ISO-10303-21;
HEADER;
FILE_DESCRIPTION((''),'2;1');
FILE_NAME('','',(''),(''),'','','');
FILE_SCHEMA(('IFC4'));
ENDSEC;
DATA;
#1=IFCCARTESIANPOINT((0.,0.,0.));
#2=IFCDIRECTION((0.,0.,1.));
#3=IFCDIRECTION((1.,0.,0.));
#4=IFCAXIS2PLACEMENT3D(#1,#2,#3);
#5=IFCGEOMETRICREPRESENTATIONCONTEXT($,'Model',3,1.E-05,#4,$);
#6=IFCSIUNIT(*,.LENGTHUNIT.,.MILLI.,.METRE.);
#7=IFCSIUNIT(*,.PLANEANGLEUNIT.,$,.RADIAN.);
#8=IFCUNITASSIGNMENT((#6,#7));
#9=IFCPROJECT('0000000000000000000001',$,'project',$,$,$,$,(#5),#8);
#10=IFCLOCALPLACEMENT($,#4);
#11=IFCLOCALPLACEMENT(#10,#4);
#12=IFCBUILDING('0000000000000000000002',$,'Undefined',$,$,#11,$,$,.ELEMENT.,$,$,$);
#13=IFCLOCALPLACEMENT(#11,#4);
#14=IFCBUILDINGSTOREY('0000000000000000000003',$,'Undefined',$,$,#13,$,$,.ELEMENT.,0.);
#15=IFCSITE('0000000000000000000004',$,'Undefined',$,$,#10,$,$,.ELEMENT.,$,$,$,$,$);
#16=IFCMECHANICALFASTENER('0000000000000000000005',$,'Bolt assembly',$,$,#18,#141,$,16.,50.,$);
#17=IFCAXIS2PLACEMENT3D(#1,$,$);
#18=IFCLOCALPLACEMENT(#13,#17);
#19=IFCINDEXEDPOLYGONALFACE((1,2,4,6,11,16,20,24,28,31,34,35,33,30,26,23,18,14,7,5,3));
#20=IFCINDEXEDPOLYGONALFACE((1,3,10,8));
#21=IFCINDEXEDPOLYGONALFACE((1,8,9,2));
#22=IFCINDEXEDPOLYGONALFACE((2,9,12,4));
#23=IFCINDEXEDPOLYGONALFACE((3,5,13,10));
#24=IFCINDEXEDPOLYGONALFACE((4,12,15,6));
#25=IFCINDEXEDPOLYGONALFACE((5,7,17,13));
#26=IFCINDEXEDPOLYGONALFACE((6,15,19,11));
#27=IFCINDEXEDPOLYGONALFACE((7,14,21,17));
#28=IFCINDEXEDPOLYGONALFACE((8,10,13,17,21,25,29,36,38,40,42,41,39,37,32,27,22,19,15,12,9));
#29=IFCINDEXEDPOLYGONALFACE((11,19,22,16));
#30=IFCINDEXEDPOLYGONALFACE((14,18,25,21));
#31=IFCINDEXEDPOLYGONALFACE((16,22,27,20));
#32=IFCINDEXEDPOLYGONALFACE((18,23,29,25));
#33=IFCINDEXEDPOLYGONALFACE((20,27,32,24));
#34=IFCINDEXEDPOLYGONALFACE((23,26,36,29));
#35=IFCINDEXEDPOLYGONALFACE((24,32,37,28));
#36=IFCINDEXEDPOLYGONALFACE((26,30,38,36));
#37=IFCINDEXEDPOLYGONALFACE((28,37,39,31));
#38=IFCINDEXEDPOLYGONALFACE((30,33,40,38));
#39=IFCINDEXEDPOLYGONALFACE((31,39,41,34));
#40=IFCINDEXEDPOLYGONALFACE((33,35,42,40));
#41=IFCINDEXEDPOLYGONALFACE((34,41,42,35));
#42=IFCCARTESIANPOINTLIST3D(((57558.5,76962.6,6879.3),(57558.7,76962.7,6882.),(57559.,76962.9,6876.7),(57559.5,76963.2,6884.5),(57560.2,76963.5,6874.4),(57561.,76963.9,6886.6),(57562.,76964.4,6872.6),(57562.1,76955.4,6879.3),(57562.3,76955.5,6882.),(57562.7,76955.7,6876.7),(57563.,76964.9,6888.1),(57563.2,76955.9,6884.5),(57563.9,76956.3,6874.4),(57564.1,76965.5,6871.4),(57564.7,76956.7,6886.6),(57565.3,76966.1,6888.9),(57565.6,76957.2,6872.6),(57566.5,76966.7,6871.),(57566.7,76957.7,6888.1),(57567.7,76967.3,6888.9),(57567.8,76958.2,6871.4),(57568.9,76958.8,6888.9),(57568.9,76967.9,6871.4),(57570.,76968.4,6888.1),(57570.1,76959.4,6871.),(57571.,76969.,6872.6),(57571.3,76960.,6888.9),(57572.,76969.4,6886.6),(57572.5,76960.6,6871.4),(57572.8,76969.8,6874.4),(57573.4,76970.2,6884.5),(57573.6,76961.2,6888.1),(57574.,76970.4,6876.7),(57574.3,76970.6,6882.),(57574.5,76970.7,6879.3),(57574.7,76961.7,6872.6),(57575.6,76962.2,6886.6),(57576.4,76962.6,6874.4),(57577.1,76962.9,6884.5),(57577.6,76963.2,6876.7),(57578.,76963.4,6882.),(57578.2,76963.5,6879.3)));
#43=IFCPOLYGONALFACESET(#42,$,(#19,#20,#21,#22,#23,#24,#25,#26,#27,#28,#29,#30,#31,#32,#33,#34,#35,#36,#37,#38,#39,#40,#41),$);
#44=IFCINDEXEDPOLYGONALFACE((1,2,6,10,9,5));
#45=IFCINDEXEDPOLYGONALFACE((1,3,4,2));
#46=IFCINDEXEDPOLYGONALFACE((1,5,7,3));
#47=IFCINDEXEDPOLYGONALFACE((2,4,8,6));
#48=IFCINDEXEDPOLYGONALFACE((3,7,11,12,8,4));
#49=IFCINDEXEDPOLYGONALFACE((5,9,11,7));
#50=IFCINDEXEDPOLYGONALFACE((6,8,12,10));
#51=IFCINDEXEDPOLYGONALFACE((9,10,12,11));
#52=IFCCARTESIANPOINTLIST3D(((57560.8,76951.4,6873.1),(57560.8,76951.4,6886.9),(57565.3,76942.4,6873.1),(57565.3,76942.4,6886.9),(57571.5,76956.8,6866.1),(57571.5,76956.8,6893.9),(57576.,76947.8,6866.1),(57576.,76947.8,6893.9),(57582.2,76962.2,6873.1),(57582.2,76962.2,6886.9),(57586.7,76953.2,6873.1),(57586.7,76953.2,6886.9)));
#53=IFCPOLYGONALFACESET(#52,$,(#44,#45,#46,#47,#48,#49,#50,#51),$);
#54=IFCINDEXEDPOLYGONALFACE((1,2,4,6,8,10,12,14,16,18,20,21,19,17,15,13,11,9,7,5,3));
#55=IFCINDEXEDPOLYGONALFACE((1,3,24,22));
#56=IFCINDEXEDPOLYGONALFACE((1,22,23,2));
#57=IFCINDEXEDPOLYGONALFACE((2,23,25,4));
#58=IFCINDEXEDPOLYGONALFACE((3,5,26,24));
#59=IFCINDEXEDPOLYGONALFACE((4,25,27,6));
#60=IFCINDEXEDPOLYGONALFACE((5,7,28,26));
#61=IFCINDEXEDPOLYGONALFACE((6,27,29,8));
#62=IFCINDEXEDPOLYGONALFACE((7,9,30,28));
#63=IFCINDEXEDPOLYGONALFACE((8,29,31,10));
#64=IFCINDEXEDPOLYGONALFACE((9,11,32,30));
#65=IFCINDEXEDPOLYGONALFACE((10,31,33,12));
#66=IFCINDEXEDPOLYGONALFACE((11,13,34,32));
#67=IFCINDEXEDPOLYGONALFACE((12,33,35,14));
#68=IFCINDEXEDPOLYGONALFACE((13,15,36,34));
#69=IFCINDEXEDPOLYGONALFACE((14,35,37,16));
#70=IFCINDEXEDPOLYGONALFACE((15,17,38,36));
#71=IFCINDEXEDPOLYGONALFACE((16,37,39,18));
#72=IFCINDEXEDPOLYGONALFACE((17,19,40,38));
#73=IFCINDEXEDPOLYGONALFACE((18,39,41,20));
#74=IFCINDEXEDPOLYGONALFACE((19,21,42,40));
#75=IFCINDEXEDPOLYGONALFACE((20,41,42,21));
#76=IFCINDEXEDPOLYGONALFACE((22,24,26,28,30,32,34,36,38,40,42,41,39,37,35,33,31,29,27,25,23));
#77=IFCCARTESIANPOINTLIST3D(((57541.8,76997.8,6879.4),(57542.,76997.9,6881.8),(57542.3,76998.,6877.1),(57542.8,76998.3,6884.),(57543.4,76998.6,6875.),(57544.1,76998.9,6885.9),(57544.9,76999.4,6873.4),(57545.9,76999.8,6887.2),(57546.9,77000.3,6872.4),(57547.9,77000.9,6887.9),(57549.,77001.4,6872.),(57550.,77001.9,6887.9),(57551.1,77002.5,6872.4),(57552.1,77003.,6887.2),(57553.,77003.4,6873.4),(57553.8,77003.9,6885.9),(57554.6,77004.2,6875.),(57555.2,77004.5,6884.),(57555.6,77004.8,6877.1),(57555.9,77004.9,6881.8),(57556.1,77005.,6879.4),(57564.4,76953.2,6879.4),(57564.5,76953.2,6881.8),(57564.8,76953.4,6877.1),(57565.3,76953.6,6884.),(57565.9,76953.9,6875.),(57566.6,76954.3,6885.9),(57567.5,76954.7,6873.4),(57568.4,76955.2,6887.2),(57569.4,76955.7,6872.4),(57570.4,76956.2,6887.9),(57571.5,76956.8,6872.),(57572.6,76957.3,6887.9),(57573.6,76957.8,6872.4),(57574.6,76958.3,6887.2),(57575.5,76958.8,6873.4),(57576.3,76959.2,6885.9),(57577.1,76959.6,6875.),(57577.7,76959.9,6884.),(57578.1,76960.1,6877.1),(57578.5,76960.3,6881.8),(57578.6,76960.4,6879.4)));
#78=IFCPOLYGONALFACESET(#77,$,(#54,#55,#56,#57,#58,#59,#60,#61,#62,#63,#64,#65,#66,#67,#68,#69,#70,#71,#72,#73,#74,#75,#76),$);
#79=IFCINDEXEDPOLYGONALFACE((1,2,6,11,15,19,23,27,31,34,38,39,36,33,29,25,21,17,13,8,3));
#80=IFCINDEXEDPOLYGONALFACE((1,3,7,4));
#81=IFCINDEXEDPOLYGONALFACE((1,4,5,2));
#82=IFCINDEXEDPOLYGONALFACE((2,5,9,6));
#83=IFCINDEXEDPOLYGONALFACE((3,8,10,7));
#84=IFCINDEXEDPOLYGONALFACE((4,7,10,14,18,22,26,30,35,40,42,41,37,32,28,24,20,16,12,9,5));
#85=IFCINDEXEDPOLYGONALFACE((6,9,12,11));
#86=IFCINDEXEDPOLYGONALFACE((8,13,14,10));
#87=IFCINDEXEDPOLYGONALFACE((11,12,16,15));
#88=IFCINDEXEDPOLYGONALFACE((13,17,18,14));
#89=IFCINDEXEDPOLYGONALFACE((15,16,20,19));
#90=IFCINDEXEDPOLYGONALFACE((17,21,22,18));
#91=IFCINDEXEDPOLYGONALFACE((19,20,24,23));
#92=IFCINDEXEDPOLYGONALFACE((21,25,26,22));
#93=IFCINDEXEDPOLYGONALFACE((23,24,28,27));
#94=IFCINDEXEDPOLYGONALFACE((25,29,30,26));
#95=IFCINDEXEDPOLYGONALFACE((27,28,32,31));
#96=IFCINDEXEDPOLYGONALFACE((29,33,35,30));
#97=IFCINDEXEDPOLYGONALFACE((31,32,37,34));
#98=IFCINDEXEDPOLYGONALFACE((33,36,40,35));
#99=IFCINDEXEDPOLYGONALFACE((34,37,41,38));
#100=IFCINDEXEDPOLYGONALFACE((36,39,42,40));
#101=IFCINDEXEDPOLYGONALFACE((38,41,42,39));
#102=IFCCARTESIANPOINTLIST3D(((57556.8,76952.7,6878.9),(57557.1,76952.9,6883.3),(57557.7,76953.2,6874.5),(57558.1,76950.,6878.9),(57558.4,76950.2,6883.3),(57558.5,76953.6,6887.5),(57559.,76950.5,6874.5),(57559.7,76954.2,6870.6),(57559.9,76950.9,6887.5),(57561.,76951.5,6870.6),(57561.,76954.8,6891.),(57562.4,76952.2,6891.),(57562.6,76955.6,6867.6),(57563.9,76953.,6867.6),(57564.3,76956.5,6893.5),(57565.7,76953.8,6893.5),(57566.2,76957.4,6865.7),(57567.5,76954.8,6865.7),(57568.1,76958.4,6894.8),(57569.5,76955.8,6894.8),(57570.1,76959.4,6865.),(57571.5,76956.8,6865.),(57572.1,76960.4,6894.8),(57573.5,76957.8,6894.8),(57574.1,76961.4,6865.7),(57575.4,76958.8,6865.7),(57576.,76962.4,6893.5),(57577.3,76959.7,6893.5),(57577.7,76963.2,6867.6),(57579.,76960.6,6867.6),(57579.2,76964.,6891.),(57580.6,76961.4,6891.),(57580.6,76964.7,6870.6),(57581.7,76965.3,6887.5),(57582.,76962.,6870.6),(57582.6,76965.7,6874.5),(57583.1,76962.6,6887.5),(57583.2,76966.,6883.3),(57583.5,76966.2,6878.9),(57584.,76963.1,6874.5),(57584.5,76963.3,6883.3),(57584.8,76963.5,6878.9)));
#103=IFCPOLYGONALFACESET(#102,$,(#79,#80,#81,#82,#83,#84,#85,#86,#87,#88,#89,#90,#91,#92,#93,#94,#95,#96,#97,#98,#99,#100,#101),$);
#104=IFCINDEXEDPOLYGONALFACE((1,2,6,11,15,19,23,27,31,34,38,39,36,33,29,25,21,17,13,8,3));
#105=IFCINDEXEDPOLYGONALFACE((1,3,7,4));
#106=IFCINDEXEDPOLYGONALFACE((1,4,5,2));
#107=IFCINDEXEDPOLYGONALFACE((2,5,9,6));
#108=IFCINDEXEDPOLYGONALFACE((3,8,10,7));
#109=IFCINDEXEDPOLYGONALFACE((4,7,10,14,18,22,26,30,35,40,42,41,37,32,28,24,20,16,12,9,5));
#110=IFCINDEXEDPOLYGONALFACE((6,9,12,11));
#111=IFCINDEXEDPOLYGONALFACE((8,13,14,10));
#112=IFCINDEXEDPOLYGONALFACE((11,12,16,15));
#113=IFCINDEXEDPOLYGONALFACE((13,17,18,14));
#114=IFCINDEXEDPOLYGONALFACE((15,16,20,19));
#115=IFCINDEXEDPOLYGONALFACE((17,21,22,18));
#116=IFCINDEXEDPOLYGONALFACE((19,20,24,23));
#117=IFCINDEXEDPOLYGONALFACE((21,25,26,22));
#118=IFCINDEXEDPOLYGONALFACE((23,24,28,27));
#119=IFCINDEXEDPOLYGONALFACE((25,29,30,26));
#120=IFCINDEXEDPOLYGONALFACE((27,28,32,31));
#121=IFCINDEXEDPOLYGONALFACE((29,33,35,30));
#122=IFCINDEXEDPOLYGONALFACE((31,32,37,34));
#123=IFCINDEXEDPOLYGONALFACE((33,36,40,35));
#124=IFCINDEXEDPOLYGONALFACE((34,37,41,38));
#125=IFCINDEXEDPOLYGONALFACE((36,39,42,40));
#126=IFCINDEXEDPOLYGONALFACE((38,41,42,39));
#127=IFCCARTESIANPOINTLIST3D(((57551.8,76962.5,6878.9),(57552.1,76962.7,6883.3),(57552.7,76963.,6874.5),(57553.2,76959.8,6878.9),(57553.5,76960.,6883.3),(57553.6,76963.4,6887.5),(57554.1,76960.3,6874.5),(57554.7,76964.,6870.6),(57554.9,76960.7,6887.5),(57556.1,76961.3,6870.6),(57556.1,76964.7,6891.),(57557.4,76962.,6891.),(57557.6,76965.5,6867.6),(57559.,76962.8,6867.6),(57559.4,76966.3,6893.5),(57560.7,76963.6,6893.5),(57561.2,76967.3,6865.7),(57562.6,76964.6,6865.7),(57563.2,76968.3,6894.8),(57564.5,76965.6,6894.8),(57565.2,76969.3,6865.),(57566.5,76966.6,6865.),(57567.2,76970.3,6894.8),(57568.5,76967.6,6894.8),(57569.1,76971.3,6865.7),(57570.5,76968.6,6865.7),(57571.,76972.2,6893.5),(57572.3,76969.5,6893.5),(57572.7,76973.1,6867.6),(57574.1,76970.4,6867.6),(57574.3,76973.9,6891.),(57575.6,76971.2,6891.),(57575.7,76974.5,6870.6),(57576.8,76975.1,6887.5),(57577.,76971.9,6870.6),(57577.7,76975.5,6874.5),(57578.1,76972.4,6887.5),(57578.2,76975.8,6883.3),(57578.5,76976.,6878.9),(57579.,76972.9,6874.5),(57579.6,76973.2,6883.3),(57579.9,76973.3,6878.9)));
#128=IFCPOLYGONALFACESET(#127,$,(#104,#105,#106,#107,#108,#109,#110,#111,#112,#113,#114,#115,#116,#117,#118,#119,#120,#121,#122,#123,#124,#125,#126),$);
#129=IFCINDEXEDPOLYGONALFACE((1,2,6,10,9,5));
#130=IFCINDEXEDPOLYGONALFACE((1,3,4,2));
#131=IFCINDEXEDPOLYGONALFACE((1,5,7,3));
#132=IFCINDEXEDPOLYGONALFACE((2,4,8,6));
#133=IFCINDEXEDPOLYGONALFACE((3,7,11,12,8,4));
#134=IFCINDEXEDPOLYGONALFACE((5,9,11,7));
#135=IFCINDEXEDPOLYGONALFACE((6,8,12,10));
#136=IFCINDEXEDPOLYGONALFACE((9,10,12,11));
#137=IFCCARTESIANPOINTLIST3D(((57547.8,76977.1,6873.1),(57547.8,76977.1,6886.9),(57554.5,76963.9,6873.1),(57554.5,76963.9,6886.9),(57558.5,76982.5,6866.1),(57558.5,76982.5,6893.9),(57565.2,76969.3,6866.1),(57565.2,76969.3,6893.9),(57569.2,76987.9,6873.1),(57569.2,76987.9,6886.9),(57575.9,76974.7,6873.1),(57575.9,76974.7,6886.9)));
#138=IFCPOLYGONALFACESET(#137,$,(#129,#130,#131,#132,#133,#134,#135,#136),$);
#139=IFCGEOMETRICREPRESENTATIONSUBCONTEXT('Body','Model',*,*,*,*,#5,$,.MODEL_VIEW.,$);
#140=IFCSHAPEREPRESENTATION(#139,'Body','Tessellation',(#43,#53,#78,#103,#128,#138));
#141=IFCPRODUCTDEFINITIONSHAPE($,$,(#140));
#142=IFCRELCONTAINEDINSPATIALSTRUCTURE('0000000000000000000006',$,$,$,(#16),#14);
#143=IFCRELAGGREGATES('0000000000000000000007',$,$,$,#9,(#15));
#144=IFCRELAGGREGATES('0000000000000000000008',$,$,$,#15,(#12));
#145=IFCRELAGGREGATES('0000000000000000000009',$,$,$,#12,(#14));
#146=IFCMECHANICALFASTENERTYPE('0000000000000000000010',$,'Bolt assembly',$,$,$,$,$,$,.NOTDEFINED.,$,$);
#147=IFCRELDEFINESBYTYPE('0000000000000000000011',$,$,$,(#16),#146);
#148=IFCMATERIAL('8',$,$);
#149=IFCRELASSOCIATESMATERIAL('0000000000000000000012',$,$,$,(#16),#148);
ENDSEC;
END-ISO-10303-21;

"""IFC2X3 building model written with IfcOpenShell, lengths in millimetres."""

from ifc_helpers import new_model, si_unit, frame, origin_with_axes, origin_2d_with_axis, place, context, subcontext, project, spatial, polyline, circle, outline, extrude, source, transform, mapped, material, type_object, element, save


model = new_model("IFC2X3")

# Units and contexts
model_context = context("Model", 3, precision=1e-05, world=origin_with_axes())
body_context = subcontext(model_context, "Body", "Model", "MODEL_VIEW")
ifc_project = project(units=[si_unit("LENGTHUNIT", "METRE", prefix="MILLI"), si_unit("PLANEANGLEUNIT", "RADIAN")], contexts=[model_context])

# Site, building, storey
site_placement = place(None, origin_with_axes())
site = spatial("IfcSite", under=ifc_project, at=site_placement, Name="Undefined", CompositionType="ELEMENT")
building_placement = place(site_placement, origin_with_axes())
building = spatial("IfcBuilding", under=site, at=building_placement, Name="Undefined", CompositionType="ELEMENT")
storey_placement = place(building_placement, origin_with_axes())
storey = spatial("IfcBuildingStorey", under=building, at=storey_placement, Name="Undefined", CompositionType="ELEMENT", Elevation=0.0)

# Mechanical fastener
ifc_material_1 = material(Name="8")
mechanical_fastener_type = type_object("IfcMechanicalFastenerType", Name="Bolt assembly")
shared_shape_1 = source(origin_with_axes(), body_context, "Body", "SweptSolid", [
    extrude(circle(Radius=9.0, at=origin_2d_with_axis()), frame((0.0, 0.0, 0.0), z_axis=(0.0, 1.0, 0.0), x_axis=(1.0, 0.0, 0.0)), (0.0, 0.0, 1.0), 8.1),
    extrude(outline(polyline([(13.9, 0.0), (6.9, 12.0), (-6.9, 12.0), (-13.9, 0.0), (-6.9, -12.0), (6.9, -12.0), (13.9, 0.0)])), frame((0.0, -13.0, 0.0), z_axis=(0.0, 1.0, 0.0), x_axis=(1.0, 0.0, 0.0)), (0.0, 0.0, 1.0), 10.0),
    extrude(circle(Radius=8.0, at=origin_2d_with_axis()), frame((0.0, -3.0, 0.0), z_axis=(0.0, 1.0, 0.0), x_axis=(1.0, 0.0, 0.0)), (0.0, 0.0, 1.0), 50.0),
    extrude(circle(Radius=15.0, at=origin_2d_with_axis()), frame((0.0, -3.0, 0.0), z_axis=(0.0, 1.0, 0.0), x_axis=(1.0, 0.0, 0.0)), (0.0, 0.0, 1.0), 3.0),
    extrude(circle(Radius=15.0, at=origin_2d_with_axis()), frame((0.0, 8.0, 0.0), z_axis=(0.0, 1.0, 0.0), x_axis=(1.0, 0.0, 0.0)), (0.0, 0.0, 1.0), 3.0),
    extrude(outline(polyline([(13.9, 0.0), (6.9, 12.0), (-6.9, 12.0), (-13.9, 0.0), (-6.9, -12.0), (6.9, -12.0), (13.9, 0.0)])), frame((0.0, 11.0, 0.0), z_axis=(0.0, 1.0, 0.0), x_axis=(1.0, 0.0, 0.0)), (0.0, 0.0, 1.0), 14.8),
])
mechanical_fastener_1_placement = place(storey_placement, frame((57570.1, 76959.4, 6880.0), z_axis=(0.892821, 0.450411, 0.0), x_axis=(-0.000057, 0.000114, -1.0)))
element("IfcMechanicalFastener", 1, at=mechanical_fastener_1_placement, inside=storey, type_object=mechanical_fastener_type, material=ifc_material_1, Name="Bolt assembly", NominalDiameter=16.0, NominalLength=50.0, context=body_context, shape_type="MappedRepresentation", body=[
    mapped(shared_shape_1, transform((0.0, 0.0, 0.0))),
])

save(model, "model.ifc")
